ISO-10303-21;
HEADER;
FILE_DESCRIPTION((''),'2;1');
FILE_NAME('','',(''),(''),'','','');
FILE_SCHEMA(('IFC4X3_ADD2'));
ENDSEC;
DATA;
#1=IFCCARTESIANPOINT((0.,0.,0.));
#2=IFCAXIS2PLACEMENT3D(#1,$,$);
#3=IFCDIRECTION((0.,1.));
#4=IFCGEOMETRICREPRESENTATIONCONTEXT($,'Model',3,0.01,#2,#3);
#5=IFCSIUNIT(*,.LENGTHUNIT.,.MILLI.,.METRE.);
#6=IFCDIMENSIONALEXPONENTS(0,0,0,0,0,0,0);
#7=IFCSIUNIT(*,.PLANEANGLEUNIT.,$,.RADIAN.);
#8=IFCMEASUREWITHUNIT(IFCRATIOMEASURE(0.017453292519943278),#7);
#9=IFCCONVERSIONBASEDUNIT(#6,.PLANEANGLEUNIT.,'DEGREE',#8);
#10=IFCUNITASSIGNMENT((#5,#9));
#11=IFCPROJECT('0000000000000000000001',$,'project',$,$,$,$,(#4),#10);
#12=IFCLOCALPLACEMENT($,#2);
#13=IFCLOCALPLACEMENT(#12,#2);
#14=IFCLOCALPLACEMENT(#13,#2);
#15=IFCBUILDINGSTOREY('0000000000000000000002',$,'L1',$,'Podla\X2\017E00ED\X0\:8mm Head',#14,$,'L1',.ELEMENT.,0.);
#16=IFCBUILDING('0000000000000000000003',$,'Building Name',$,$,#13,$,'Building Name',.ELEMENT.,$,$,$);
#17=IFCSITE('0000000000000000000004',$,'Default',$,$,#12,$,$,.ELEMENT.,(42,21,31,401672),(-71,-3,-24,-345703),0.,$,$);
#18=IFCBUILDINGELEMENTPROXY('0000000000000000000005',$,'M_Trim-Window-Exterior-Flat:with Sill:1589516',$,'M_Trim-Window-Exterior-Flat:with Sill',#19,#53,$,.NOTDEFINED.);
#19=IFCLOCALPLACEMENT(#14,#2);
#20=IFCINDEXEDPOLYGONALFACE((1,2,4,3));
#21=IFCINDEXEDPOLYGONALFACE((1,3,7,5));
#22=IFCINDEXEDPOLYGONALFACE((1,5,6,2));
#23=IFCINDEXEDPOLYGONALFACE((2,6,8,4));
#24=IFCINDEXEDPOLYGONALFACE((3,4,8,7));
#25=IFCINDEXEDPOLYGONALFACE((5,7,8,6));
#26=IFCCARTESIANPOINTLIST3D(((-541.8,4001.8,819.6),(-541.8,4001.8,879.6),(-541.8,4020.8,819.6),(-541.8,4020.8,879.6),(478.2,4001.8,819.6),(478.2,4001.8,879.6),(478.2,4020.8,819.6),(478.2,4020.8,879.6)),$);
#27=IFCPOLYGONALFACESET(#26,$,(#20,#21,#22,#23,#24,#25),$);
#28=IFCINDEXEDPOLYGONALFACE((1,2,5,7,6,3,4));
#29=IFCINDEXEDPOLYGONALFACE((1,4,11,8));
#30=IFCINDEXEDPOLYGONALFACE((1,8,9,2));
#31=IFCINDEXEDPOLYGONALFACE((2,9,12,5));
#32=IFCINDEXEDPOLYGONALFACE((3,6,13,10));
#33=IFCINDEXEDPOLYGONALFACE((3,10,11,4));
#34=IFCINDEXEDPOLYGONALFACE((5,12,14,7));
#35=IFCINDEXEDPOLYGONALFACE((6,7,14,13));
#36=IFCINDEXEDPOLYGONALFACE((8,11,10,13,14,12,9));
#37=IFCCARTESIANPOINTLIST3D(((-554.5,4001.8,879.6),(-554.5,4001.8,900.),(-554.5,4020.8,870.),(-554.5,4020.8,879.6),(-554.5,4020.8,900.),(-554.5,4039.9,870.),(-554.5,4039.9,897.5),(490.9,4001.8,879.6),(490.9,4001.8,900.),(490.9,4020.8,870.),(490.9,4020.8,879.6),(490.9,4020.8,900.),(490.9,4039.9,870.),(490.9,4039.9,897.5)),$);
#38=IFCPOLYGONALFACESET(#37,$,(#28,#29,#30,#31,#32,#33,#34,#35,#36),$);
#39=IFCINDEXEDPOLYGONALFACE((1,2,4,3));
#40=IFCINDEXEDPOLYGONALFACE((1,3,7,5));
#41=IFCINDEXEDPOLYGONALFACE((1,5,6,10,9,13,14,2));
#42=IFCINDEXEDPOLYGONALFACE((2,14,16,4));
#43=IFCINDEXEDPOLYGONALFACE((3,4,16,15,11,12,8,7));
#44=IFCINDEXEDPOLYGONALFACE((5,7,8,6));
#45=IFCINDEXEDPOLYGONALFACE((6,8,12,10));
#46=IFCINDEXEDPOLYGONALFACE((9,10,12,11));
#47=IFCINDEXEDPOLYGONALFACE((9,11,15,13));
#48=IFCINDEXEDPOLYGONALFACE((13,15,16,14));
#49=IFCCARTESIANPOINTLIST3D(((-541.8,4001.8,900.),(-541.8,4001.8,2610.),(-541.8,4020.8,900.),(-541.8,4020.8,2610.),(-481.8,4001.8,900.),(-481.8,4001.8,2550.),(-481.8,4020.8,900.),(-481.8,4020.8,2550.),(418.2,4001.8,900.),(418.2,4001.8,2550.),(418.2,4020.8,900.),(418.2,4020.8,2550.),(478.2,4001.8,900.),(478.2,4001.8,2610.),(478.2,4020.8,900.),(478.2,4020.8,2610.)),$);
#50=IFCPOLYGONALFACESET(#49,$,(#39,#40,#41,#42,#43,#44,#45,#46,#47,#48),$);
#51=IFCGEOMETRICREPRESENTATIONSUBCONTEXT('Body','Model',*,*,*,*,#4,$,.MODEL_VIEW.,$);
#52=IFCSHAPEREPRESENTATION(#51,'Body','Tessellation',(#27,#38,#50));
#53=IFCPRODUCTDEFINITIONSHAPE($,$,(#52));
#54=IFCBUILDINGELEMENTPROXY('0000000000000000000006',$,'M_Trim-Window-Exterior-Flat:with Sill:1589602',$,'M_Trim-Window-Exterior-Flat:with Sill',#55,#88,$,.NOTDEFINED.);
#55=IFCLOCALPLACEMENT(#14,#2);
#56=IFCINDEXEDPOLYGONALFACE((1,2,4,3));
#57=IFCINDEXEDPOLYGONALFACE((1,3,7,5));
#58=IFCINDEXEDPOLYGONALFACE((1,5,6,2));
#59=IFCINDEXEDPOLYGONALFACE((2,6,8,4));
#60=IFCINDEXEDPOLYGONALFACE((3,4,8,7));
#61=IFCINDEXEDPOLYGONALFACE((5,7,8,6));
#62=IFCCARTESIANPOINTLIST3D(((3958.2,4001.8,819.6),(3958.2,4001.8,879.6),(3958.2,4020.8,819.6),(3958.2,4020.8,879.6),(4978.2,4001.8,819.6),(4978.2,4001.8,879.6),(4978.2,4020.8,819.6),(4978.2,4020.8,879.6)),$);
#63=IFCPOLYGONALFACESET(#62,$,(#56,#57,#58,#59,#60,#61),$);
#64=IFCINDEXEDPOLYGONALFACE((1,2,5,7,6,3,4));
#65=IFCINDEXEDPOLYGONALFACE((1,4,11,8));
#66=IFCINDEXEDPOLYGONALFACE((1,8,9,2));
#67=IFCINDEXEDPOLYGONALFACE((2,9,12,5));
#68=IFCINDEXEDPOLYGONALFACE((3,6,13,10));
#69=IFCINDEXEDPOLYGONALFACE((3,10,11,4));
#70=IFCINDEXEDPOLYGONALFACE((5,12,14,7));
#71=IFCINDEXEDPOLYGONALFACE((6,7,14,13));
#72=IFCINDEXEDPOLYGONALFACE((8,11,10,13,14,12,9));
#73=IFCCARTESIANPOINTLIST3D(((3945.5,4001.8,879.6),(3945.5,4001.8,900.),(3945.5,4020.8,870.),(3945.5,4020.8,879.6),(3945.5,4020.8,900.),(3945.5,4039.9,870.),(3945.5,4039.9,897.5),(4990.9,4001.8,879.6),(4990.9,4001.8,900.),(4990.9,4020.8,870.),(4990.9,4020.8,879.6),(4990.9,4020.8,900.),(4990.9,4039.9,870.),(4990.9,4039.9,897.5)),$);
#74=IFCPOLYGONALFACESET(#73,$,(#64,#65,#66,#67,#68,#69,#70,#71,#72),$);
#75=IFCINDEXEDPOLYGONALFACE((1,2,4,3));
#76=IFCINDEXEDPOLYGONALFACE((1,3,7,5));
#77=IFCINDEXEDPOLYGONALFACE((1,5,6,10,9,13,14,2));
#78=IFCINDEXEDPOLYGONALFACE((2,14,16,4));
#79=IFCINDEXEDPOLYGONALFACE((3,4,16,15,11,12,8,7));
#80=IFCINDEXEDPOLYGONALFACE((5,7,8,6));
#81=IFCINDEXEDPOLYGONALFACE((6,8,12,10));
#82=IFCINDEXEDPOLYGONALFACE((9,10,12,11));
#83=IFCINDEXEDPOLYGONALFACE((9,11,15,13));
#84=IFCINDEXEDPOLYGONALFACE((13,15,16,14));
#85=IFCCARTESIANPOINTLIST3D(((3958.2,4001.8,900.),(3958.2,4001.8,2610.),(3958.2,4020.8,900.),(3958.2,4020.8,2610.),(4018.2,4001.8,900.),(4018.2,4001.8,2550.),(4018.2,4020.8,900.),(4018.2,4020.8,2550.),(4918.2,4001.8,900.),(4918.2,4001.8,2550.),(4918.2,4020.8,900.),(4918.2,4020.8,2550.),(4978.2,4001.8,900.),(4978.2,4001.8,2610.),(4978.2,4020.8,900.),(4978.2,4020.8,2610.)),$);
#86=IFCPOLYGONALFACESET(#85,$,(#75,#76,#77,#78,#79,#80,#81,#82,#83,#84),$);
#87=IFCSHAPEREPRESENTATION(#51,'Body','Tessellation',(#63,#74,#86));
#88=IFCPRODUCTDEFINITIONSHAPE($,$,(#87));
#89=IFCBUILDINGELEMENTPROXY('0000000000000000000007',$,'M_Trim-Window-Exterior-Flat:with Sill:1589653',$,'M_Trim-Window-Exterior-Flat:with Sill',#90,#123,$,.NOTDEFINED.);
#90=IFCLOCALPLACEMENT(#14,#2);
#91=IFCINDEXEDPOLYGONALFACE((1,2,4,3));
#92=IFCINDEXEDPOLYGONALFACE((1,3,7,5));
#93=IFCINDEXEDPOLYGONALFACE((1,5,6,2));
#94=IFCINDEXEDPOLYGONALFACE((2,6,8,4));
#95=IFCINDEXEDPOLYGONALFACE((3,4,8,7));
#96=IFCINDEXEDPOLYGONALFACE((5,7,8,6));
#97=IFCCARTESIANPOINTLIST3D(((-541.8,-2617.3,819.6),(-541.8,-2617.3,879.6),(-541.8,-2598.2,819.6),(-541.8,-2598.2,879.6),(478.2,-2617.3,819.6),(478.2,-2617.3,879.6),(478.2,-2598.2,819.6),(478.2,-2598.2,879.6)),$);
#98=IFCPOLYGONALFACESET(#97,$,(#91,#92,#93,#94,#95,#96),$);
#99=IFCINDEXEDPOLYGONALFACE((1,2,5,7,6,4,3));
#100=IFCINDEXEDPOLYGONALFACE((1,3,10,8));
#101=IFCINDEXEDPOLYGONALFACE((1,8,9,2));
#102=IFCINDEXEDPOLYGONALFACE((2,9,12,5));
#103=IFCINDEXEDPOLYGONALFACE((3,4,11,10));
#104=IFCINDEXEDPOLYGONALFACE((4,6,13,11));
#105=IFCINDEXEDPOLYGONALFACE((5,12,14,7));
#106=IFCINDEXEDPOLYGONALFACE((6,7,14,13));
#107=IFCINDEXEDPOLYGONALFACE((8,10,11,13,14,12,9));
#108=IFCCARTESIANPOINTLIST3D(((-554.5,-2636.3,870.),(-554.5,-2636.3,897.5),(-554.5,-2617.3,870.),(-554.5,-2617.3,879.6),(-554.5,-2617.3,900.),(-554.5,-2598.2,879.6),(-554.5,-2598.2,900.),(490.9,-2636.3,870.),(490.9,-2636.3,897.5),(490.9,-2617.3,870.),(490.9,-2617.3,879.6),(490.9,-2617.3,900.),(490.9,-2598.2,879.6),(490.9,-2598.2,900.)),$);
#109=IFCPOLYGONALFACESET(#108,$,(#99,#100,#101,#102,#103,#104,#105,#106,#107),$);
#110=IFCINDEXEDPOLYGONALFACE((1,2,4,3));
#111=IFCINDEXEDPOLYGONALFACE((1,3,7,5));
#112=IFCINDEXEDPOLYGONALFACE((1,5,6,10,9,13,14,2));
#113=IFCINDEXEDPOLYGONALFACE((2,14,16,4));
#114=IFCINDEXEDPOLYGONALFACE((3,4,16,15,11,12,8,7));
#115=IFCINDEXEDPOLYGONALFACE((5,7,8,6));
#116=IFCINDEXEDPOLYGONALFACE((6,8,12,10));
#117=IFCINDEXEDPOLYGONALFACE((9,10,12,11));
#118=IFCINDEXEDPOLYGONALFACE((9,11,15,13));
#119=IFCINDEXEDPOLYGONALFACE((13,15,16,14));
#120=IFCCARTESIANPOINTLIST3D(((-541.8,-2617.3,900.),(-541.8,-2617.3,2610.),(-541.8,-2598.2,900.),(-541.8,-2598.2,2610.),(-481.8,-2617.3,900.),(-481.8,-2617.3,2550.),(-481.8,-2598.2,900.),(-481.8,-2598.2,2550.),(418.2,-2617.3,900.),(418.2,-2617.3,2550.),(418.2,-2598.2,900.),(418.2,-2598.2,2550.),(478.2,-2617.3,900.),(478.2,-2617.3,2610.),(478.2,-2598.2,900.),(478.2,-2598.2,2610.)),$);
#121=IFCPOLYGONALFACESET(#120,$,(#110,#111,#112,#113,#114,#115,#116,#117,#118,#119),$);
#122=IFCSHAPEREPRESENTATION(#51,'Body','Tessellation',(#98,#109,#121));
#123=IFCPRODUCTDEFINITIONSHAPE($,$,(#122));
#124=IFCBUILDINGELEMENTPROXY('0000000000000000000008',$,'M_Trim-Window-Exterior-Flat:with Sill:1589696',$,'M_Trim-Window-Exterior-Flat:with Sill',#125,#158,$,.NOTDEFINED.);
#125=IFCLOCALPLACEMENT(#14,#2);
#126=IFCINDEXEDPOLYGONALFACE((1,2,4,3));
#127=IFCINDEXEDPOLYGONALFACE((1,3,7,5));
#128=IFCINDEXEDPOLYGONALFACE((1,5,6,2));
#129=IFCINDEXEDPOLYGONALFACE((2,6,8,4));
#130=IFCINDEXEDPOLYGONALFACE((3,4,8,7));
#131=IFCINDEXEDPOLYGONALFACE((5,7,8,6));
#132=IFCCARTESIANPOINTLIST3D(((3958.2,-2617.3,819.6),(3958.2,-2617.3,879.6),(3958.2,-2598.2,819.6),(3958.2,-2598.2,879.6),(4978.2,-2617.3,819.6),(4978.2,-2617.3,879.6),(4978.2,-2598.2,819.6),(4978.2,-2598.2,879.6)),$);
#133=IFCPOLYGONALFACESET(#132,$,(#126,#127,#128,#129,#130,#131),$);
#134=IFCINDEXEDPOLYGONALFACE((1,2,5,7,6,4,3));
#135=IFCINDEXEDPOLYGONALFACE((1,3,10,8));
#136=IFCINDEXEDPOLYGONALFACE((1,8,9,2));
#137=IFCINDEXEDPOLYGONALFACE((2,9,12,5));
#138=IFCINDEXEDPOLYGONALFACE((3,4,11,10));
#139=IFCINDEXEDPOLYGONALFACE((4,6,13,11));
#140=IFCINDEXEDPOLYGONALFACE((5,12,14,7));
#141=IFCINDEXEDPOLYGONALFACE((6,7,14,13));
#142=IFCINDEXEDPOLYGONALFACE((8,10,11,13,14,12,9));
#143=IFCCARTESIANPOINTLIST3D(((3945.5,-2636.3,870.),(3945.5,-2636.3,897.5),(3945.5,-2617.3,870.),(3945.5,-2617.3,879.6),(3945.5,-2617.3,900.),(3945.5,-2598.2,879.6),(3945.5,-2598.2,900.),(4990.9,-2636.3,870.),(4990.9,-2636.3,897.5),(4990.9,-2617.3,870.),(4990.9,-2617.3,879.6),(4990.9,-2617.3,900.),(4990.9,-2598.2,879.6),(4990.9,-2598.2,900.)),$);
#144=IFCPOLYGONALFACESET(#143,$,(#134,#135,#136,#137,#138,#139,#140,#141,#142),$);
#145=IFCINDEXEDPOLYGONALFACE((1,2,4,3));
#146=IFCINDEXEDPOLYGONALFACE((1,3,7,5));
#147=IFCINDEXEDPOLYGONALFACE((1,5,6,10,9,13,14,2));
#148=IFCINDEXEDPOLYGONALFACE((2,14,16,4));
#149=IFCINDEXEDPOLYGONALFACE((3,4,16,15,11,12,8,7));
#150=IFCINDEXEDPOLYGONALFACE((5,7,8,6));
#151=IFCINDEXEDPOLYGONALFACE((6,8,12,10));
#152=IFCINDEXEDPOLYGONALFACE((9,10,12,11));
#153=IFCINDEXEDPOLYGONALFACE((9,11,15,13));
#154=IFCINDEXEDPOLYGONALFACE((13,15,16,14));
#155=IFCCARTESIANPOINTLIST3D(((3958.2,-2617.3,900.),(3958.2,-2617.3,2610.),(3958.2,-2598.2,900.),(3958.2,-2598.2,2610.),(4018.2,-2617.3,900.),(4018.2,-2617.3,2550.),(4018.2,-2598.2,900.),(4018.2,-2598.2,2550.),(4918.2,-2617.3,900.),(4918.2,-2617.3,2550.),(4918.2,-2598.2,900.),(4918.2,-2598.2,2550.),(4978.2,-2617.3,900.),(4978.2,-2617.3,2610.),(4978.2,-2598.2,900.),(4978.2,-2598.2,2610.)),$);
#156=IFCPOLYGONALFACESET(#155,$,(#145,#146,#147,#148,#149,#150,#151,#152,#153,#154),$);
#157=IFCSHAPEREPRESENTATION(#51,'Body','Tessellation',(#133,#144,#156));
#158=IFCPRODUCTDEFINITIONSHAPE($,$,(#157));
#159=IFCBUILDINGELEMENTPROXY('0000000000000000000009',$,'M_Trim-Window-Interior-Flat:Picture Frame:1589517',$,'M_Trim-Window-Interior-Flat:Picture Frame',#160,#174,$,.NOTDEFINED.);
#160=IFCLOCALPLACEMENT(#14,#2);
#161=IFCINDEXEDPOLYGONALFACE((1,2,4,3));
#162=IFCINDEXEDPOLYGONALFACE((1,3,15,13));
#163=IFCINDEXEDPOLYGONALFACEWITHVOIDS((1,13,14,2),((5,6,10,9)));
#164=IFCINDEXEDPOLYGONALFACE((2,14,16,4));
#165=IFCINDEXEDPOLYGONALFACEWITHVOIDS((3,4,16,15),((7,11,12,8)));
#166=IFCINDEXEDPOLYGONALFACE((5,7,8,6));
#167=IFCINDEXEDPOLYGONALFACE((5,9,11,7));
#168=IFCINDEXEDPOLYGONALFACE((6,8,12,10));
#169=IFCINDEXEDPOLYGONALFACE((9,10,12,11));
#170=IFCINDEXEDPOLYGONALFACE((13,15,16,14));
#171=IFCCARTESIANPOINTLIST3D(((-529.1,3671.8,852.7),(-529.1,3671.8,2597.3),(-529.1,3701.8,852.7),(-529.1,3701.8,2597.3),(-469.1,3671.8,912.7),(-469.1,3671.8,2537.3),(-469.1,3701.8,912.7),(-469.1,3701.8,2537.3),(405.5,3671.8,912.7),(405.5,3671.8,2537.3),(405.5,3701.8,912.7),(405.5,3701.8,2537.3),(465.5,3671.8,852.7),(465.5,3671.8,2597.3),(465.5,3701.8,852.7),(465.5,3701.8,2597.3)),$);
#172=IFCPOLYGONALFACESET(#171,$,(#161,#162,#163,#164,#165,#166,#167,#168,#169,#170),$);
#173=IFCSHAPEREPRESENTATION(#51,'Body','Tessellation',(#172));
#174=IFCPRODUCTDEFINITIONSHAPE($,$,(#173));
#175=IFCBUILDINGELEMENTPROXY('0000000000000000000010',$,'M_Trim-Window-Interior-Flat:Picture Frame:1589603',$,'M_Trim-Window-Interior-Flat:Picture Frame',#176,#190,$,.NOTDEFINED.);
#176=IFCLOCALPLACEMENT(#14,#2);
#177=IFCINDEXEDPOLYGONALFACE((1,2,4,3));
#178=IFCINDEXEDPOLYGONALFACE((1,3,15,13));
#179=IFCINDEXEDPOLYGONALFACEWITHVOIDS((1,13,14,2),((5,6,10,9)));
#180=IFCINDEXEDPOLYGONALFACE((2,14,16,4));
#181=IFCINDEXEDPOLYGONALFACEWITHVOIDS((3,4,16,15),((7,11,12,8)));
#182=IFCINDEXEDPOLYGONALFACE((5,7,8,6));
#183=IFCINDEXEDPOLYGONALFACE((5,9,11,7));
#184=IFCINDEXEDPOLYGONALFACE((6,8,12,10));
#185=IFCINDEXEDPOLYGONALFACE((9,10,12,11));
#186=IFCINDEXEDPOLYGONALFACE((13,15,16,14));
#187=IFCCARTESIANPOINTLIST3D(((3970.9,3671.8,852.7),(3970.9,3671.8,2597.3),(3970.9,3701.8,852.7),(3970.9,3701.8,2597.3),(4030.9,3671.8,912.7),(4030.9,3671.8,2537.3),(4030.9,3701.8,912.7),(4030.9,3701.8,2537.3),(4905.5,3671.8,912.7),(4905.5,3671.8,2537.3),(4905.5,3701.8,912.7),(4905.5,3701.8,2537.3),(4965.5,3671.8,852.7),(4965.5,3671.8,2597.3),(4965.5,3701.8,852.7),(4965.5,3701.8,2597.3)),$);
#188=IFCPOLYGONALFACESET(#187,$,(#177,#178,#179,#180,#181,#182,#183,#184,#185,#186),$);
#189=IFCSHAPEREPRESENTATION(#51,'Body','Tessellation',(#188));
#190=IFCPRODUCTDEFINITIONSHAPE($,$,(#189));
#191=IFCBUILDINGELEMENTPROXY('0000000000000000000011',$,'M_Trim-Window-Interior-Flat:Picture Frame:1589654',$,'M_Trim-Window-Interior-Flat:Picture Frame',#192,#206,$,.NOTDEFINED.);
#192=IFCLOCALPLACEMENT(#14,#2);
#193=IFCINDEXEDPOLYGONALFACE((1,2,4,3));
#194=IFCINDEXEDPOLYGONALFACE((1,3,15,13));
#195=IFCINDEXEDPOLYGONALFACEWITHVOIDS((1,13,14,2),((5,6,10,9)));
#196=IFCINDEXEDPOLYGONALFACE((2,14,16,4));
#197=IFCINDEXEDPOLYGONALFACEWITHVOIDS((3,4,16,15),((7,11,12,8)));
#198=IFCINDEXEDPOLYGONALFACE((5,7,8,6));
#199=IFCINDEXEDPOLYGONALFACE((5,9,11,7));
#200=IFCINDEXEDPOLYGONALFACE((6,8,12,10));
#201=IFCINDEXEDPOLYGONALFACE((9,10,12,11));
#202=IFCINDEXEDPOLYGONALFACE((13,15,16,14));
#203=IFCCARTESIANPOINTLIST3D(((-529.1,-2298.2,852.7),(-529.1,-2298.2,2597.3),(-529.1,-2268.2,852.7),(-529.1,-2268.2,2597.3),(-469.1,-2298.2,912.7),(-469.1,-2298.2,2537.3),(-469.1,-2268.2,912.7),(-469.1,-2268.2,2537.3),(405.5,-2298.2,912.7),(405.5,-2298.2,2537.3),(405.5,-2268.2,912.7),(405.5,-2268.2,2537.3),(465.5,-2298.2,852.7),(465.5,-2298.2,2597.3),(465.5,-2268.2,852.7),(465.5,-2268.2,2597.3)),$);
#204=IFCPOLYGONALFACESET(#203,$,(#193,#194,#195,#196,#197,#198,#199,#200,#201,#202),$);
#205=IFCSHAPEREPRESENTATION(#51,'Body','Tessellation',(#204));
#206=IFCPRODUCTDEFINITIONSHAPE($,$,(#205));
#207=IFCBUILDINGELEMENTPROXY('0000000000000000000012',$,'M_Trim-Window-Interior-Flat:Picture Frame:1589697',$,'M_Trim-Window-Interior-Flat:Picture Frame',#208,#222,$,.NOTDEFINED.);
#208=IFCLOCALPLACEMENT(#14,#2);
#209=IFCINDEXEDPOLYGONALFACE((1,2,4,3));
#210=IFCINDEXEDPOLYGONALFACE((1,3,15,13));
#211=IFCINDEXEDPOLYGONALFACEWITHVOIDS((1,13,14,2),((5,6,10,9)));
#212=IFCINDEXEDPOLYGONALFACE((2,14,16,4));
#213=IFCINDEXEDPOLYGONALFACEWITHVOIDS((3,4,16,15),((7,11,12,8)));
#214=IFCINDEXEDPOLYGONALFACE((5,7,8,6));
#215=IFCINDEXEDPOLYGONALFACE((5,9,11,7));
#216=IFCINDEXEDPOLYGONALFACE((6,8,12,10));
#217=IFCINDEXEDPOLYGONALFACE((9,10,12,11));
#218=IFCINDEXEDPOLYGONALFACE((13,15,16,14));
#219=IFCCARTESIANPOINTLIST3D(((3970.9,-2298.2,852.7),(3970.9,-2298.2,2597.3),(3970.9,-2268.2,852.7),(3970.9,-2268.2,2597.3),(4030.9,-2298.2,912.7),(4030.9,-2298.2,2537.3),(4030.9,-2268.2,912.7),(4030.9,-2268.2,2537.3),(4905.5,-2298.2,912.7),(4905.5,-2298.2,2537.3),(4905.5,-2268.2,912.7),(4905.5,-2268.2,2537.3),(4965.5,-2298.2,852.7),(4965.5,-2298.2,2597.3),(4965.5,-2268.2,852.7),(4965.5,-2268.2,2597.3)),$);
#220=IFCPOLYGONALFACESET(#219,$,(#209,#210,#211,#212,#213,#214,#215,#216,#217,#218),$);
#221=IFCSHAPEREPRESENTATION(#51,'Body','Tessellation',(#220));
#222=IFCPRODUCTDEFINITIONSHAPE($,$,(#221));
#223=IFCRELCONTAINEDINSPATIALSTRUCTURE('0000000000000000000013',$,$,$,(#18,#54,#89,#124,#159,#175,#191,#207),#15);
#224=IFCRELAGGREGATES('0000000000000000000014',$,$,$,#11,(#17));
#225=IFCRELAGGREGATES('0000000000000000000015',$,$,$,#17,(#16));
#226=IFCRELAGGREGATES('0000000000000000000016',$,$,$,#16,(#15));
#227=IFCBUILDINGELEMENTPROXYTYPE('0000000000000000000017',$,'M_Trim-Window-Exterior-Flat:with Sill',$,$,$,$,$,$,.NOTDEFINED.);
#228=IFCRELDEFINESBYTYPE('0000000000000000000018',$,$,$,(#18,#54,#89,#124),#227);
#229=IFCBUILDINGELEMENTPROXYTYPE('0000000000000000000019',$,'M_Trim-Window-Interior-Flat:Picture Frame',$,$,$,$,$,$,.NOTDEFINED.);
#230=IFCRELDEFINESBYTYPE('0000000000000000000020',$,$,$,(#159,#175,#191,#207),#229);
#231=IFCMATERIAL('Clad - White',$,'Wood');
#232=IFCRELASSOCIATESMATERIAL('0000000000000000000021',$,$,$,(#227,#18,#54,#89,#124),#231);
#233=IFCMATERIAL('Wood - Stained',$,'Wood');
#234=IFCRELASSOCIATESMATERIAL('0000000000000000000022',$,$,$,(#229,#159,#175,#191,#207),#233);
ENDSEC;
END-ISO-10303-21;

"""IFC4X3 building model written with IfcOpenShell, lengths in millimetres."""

from ifc_helpers import new_model, entity, si_unit, converted_unit, direction, frame, frame_2d, origin, place, context, subcontext, project, spatial, polyline, rectangle, outline, extrude, source, transform, mapped, material, type_object, type_shapes, element, save


model = new_model("IFC4X3")

# Units and contexts
model_context = context("Model", 3, precision=0.01, world=origin(), true_north=direction((0.0, 1.0)))
body_context = subcontext(model_context, "Body", "Model", "MODEL_VIEW")
ifc_project = project(units=[si_unit("LENGTHUNIT", "METRE", prefix="MILLI"), converted_unit("PLANEANGLEUNIT", "DEGREE", entity("IfcRatioMeasure", 0.017453292519943278), si_unit("PLANEANGLEUNIT", "RADIAN"), dimensions=[0, 0, 0, 0, 0, 0, 0])], contexts=[model_context])

# Site, building, storey
site_placement = place(None, origin())
site = spatial("IfcSite", under=ifc_project, at=site_placement, Name="Default", CompositionType="ELEMENT", RefLatitude=(42, 21, 31, 401672), RefLongitude=(-71, -3, -24, -345703), RefElevation=0.0)
building_placement = place(site_placement, origin())
building = spatial("IfcBuilding", under=site, at=building_placement, Name="Building Name", LongName="Building Name", CompositionType="ELEMENT")
storey_placement = place(building_placement, origin())
storey = spatial("IfcBuildingStorey", under=building, at=storey_placement, Name="L1", ObjectType="Podlaží:8mm Head", LongName="L1", CompositionType="ELEMENT", Elevation=0.0)

# Building element proxies
ifc_material_1 = material(Name="Clad - White", Category="Wood")
ifc_material_2 = material(Name="Wood - Stained", Category="Wood")
building_element_proxy_type_1 = type_object("IfcBuildingElementProxyType", Name="M_Trim-Window-Exterior-Flat:with Sill", PredefinedType="NOTDEFINED", material=ifc_material_1)
shared_shape_1 = source(origin(), body_context, "Body", "SweptSolid", [
    extrude(rectangle(XDim=1020.0, YDim=60.0, at=frame_2d((0.0, 0.0), x_axis=(1.0, 0.0))), frame((0.0, -1700.4, 0.0), z_axis=(0.0, 0.0, 1.0), x_axis=(-1.0, 0.0, 0.0)), (0.0, 0.0, 1.0), 19.0),
    extrude(outline(polyline([(-19.0, -15.2), (0.0, -15.2), (0.0, -5.7), (19.0, -5.7), (19.0, 14.8), (0.0, 14.8), (-19.0, 12.3), (-19.0, -15.2)])), frame((-522.7, -1664.8, 19.0), z_axis=(1.0, 0.0, 0.0), x_axis=(0.0, 0.0, -1.0)), (0.0, 0.0, 1.0), 1045.4),
    extrude(outline(polyline([(-870.0, -510.0), (840.0, -510.0), (840.0, -450.0), (-810.0, -450.0), (-810.0, 450.0), (840.0, 450.0), (840.0, 510.0), (-870.0, 510.0), (-870.0, -510.0)])), frame((0.0, -810.0, 0.0), z_axis=(0.0, 0.0, 1.0), x_axis=(0.0, -1.0, 0.0)), (0.0, 0.0, 1.0), 19.0),
])
type_shapes(building_element_proxy_type_1, [shared_shape_1])
for number, where, z_axis, x_axis, name in (
    (1, (-31.8, 4001.8, 2550.0), (0.0, 1.0, 0.0), (-1.0, 0.0, 0.0), "M_Trim-Window-Exterior-Flat:with Sill:1589516"),
    (2, (4468.2, 4001.8, 2550.0), (0.0, 1.0, 0.0), (-1.0, 0.0, 0.0), "M_Trim-Window-Exterior-Flat:with Sill:1589602"),
    (3, (-31.8, -2598.2, 2550.0), (0.0, -1.0, 0.0), (1.0, 0.0, 0.0), "M_Trim-Window-Exterior-Flat:with Sill:1589653"),
    (4, (4468.2, -2598.2, 2550.0), (0.0, -1.0, 0.0), (1.0, 0.0, 0.0), "M_Trim-Window-Exterior-Flat:with Sill:1589696"),
):
    element("IfcBuildingElementProxy", number, at=place(storey_placement, frame(where, z_axis=z_axis, x_axis=x_axis)), inside=storey, type_object=building_element_proxy_type_1, material=ifc_material_1, Name=name, ObjectType="M_Trim-Window-Exterior-Flat:with Sill", PredefinedType="NOTDEFINED", context=body_context, shape_type="MappedRepresentation", body=[
        mapped(shared_shape_1, transform((0.0, 0.0, 0.0), scale=1.0)),
    ])
building_element_proxy_type_2 = type_object("IfcBuildingElementProxyType", Name="M_Trim-Window-Interior-Flat:Picture Frame", PredefinedType="NOTDEFINED", material=ifc_material_2)
shared_shape_2 = source(origin(), body_context, "Body", "SweptSolid", [
    extrude(outline(polyline([(-497.3, -872.3), (497.3, -872.3), (497.3, 872.3), (-497.3, 872.3), (-497.3, -872.3)]), holes=[polyline([(-437.3, -812.3), (-437.3, 812.3), (437.3, 812.3), (437.3, -812.3), (-437.3, -812.3)])]), frame((0.0, -825.0, 0.0), z_axis=(0.0, 0.0, 1.0), x_axis=(-1.0, 0.0, 0.0)), (0.0, 0.0, 1.0), 30.0),
])
type_shapes(building_element_proxy_type_2, [shared_shape_2])
for number, where, z_axis, x_axis, name in (
    (5, (-31.8, 3701.8, 2550.0), (0.0, -1.0, 0.0), (1.0, 0.0, 0.0), "M_Trim-Window-Interior-Flat:Picture Frame:1589517"),
    (6, (4468.2, 3701.8, 2550.0), (0.0, -1.0, 0.0), (1.0, 0.0, 0.0), "M_Trim-Window-Interior-Flat:Picture Frame:1589603"),
    (7, (-31.8, -2298.2, 2550.0), (0.0, 1.0, 0.0), (-1.0, 0.0, 0.0), "M_Trim-Window-Interior-Flat:Picture Frame:1589654"),
    (8, (4468.2, -2298.2, 2550.0), (0.0, 1.0, 0.0), (-1.0, 0.0, 0.0), "M_Trim-Window-Interior-Flat:Picture Frame:1589697"),
):
    element("IfcBuildingElementProxy", number, at=place(storey_placement, frame(where, z_axis=z_axis, x_axis=x_axis)), inside=storey, type_object=building_element_proxy_type_2, material=ifc_material_2, Name=name, ObjectType="M_Trim-Window-Interior-Flat:Picture Frame", PredefinedType="NOTDEFINED", context=body_context, shape_type="MappedRepresentation", body=[
        mapped(shared_shape_2, transform((0.0, 0.0, 0.0), scale=1.0)),
    ])

save(model, "model.ifc")
